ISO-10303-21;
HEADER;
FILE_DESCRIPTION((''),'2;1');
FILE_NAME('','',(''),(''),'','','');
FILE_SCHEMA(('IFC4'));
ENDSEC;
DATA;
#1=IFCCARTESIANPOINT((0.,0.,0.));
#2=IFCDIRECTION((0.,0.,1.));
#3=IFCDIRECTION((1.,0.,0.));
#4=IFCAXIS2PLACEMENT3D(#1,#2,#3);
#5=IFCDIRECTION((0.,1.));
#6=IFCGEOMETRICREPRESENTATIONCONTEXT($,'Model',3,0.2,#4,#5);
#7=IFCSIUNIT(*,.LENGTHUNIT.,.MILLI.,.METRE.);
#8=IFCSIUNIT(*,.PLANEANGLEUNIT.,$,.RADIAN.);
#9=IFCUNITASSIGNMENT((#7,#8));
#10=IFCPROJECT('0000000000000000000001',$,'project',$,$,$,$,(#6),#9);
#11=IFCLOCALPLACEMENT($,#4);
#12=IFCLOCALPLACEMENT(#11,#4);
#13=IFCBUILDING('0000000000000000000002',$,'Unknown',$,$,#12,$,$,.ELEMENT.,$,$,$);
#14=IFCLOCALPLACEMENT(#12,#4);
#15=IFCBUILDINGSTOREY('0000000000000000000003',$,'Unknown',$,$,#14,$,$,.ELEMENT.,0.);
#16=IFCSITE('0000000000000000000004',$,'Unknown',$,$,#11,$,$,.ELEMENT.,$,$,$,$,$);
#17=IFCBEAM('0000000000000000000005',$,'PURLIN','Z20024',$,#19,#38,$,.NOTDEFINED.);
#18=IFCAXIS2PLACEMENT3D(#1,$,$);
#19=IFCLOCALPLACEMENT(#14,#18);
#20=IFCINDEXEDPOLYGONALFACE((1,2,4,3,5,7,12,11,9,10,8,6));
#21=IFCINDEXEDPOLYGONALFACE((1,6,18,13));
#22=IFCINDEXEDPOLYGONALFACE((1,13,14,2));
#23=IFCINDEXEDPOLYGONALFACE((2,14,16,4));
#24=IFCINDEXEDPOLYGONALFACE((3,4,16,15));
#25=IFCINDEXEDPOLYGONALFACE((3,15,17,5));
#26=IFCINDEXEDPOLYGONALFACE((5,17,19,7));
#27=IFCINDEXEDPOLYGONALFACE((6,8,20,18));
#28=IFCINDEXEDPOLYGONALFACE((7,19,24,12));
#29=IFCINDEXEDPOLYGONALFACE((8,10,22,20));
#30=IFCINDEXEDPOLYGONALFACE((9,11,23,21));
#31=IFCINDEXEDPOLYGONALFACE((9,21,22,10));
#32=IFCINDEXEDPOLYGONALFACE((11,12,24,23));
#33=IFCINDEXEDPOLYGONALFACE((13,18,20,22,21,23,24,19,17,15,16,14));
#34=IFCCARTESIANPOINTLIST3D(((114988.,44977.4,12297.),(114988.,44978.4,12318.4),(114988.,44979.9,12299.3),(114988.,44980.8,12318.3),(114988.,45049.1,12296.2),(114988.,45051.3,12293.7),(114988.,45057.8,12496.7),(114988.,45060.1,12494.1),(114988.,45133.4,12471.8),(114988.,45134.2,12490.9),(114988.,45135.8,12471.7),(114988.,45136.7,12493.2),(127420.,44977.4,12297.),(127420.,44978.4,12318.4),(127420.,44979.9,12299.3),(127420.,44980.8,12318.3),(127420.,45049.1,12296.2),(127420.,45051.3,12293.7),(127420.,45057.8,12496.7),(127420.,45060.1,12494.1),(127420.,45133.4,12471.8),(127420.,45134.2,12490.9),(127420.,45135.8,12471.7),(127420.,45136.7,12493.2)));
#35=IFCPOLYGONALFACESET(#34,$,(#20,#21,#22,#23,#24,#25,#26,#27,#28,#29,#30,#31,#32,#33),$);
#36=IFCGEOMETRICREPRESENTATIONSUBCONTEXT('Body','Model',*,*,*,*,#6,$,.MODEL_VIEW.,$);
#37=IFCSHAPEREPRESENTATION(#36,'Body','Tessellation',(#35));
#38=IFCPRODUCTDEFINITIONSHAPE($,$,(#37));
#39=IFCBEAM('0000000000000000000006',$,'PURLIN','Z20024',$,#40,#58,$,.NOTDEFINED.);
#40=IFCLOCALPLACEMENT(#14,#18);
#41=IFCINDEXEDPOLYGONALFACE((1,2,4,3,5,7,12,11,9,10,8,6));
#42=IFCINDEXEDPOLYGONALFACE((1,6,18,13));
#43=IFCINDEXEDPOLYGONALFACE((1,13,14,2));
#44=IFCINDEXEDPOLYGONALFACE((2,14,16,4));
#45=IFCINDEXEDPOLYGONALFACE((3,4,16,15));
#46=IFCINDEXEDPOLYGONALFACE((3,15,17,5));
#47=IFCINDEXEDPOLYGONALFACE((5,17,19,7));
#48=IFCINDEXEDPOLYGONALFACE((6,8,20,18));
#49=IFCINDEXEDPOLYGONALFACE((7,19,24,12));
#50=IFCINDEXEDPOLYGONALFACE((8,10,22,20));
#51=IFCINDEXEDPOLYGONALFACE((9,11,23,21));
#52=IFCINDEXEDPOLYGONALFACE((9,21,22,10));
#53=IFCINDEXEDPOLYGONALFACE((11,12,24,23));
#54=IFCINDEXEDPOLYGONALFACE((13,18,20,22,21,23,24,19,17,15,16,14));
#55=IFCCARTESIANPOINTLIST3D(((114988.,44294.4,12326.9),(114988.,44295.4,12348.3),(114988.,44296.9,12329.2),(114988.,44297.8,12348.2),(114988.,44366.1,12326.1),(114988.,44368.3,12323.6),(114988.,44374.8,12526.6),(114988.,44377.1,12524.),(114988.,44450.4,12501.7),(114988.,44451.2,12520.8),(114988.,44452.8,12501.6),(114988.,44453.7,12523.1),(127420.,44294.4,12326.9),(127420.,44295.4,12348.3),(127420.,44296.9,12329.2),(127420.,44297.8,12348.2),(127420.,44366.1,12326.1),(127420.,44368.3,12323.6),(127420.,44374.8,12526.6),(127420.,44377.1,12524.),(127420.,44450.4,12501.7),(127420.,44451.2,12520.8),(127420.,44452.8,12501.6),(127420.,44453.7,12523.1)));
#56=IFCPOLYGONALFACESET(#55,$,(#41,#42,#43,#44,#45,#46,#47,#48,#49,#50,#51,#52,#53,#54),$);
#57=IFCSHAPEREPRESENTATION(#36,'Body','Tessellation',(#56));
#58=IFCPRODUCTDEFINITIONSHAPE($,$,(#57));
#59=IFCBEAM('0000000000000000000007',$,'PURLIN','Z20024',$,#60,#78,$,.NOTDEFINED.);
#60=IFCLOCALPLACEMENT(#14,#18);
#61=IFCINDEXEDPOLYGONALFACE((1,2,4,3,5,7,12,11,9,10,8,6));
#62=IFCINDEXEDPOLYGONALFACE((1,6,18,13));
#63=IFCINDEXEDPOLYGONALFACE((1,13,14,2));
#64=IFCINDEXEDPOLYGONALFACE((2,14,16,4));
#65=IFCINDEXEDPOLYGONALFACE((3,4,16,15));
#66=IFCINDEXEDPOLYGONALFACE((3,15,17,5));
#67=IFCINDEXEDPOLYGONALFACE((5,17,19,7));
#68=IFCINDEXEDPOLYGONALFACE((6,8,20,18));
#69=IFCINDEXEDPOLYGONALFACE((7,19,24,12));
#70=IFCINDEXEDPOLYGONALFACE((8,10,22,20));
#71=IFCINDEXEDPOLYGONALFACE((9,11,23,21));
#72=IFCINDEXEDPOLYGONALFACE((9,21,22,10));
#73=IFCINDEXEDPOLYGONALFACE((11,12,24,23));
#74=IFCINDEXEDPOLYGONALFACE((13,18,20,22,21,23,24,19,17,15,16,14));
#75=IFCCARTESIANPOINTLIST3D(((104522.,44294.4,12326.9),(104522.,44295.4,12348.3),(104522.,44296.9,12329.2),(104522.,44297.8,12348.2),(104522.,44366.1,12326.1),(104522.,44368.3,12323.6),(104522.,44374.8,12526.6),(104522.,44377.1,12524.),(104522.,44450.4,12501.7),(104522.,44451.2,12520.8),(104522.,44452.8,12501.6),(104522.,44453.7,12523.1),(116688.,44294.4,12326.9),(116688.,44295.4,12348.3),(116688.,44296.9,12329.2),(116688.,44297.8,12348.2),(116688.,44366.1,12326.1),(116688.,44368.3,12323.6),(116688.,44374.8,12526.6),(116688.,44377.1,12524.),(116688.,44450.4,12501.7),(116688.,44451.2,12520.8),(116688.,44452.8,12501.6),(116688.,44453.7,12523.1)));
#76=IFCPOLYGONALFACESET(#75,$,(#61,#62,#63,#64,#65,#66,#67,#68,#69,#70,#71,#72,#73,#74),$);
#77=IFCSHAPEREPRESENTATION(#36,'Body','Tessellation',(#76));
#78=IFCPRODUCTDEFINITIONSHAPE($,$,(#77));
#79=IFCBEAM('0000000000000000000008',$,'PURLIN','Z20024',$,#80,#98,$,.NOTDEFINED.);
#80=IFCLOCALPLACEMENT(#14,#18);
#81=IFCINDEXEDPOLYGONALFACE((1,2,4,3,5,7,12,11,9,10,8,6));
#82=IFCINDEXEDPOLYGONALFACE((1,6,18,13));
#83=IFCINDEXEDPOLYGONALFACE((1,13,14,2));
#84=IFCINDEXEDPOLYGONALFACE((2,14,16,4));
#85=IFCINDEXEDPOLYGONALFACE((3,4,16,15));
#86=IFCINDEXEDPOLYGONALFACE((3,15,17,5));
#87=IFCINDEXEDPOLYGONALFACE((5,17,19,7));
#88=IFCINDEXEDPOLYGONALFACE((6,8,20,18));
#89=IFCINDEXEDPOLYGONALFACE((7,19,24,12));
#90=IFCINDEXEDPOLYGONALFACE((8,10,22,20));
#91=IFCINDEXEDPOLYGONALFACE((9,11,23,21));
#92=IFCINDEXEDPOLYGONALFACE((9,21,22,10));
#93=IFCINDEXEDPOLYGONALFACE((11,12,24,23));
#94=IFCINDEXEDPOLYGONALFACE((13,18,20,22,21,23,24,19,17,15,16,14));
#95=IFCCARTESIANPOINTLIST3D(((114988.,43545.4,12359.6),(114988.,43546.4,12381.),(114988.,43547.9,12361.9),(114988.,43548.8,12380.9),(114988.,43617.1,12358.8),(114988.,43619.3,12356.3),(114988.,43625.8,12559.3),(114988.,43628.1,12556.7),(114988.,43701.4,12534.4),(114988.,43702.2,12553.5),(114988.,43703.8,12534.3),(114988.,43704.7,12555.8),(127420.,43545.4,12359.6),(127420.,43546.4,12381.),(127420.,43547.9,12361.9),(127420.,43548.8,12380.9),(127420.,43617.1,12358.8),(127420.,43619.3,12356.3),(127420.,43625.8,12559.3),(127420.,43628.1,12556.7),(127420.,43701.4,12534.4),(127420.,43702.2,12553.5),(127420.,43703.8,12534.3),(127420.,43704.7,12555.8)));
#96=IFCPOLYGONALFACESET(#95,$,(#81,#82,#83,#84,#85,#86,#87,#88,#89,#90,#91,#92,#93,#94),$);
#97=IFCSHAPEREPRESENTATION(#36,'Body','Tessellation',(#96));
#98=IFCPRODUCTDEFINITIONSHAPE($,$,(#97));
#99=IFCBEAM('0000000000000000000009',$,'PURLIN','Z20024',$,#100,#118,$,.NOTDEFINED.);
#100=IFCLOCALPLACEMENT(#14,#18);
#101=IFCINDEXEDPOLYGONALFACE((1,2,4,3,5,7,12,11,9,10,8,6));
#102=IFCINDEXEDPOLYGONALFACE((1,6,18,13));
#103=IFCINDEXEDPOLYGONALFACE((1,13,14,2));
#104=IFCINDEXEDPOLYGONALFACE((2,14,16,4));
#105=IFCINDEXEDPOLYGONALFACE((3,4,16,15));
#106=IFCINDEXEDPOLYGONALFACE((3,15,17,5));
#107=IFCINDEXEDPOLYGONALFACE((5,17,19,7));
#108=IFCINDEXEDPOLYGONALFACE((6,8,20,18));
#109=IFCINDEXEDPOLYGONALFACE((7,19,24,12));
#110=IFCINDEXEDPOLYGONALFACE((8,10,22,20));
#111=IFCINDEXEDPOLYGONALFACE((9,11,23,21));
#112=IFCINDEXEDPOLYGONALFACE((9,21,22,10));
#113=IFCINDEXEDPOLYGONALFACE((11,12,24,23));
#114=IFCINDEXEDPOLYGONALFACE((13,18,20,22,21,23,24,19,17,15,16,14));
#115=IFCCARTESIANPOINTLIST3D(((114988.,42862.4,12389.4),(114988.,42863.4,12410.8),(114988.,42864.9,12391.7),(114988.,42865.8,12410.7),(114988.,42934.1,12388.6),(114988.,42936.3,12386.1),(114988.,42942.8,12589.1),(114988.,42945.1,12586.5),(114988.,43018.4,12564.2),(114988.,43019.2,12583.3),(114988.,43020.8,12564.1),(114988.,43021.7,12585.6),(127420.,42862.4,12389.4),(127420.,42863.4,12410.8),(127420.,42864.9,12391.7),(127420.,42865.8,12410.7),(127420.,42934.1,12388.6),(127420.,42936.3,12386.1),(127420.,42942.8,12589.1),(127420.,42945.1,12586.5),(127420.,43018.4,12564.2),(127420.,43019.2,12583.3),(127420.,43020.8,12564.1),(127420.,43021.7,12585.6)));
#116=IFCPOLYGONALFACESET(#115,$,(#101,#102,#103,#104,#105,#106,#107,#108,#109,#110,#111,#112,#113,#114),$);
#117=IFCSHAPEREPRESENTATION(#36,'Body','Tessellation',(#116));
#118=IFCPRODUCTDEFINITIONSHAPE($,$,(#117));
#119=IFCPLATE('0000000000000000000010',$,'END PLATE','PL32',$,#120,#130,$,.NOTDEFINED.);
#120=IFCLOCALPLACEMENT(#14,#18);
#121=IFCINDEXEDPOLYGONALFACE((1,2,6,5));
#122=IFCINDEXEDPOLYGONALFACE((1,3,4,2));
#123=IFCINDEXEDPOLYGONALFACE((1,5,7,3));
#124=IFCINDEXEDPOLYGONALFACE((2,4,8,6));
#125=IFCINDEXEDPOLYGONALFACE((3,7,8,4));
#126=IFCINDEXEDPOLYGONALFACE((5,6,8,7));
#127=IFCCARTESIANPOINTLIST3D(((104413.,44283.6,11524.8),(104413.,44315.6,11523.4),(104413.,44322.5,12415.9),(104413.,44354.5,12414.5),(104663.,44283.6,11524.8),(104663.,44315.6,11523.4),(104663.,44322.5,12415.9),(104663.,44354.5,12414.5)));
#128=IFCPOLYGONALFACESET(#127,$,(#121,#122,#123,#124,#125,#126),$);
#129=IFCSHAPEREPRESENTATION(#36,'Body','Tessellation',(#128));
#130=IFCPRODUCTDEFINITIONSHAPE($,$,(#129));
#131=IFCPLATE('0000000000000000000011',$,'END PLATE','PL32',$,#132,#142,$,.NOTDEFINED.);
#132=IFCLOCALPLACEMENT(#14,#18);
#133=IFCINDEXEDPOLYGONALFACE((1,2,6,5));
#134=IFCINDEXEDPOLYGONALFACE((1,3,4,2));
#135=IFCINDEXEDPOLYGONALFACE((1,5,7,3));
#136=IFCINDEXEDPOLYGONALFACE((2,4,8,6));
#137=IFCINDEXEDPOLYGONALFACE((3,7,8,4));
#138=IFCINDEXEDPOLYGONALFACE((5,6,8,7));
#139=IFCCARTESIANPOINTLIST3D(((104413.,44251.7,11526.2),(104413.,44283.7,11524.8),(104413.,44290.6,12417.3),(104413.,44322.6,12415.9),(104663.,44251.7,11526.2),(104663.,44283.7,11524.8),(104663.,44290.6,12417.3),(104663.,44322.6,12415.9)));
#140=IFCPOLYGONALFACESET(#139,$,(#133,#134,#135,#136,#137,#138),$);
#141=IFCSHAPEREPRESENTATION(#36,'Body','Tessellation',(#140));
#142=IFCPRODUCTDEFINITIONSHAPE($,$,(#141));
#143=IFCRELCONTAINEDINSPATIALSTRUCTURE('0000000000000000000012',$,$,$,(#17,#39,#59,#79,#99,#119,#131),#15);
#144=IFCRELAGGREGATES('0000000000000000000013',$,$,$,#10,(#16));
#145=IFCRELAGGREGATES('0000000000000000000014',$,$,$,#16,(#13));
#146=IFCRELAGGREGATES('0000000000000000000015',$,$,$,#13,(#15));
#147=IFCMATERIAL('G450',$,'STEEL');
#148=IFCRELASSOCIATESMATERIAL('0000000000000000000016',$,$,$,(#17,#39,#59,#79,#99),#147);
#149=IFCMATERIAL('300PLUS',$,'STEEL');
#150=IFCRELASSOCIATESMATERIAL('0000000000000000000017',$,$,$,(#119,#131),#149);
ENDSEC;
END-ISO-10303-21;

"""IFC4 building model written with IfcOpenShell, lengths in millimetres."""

from ifc_helpers import new_model, si_unit, direction, frame, origin_with_axes, place, context, subcontext, project, spatial, line, indexed_curve, outline, extrude, material, element, save


model = new_model("IFC4")

# Units and contexts
model_context = context("Model", 3, precision=0.2, world=origin_with_axes(), true_north=direction((0.0, 1.0)))
body_context = subcontext(model_context, "Body", "Model", "MODEL_VIEW")
ifc_project = project(units=[si_unit("LENGTHUNIT", "METRE", prefix="MILLI"), si_unit("PLANEANGLEUNIT", "RADIAN")], contexts=[model_context])

# Site, building, storey
site_placement = place(None, origin_with_axes())
site = spatial("IfcSite", under=ifc_project, at=site_placement, Name="Unknown", CompositionType="ELEMENT")
building_placement = place(site_placement, origin_with_axes())
building = spatial("IfcBuilding", under=site, at=building_placement, Name="Unknown", CompositionType="ELEMENT")
storey_placement = place(building_placement, origin_with_axes())
storey = spatial("IfcBuildingStorey", under=building, at=storey_placement, Name="Unknown", CompositionType="ELEMENT", Elevation=0.0)

# Beams
ifc_material_1 = material(Name="G450", Category="STEEL")
for number, where, z_axis, x_axis, name in (
    (1, (114988.0, 45054.6, 12395.2), (0.0, -0.999048, 0.043619), (1.0, 0.0, 0.0), "PURLIN"),
    (2, (114988.0, 44371.6, 12425.1), (0.0, -0.999048, 0.043619), (1.0, 0.0, 0.0), "PURLIN"),
):
    element("IfcBeam", number, at=place(storey_placement, frame(where, z_axis=z_axis, x_axis=x_axis)), inside=storey, material=ifc_material_1, Name=name, Description="Z20024", PredefinedType="NOTDEFINED", context=body_context, shape_type="SolidModel", body=[
        extrude(outline(indexed_curve([(72.8, -101.5), (72.8, -80.0), (70.4, -80.0), (70.4, -99.1), (1.2, -99.1), (1.2, 101.5), (-77.8, 101.5), (-77.8, 80.0), (-75.4, 80.0), (-75.4, 99.1), (-1.2, 99.1), (-1.2, -101.5)], segments=[line(1, 2, 3, 4, 5, 6, 7, 8, 9, 10, 11, 12, 1)])), frame((0.0, 0.0, 0.0), z_axis=(-1.0, 0.0, 0.0), x_axis=(0.0, 0.0, 1.0)), (0.0, 0.0, -1.0), 12432.0),
    ])
beam_1_placement = place(storey_placement, frame((104522.0, 44371.6, 12425.1), z_axis=(0.0, -0.999048, 0.043619), x_axis=(1.0, 0.0, 0.0)))
element("IfcBeam", 3, at=beam_1_placement, inside=storey, material=ifc_material_1, Name="PURLIN", Description="Z20024", PredefinedType="NOTDEFINED", context=body_context, shape_type="SolidModel", body=[
    extrude(outline(indexed_curve([(72.8, -101.5), (72.8, -80.0), (70.4, -80.0), (70.4, -99.1), (1.2, -99.1), (1.2, 101.5), (-77.8, 101.5), (-77.8, 80.0), (-75.4, 80.0), (-75.4, 99.1), (-1.2, 99.1), (-1.2, -101.5)], segments=[line(1, 2, 3, 4, 5, 6, 7, 8, 9, 10, 11, 12, 1)])), frame((0.0, 0.0, 0.0), z_axis=(-1.0, 0.0, 0.0), x_axis=(0.0, 0.0, 1.0)), (0.0, 0.0, -1.0), 12166.0),
])
for number, where, z_axis, x_axis, name in (
    (4, (114988.0, 43622.6, 12457.8), (0.0, -0.999048, 0.043619), (1.0, 0.0, 0.0), "PURLIN"),
    (5, (114988.0, 42939.6, 12487.6), (0.0, -0.999048, 0.043619), (1.0, 0.0, 0.0), "PURLIN"),
):
    element("IfcBeam", number, at=place(storey_placement, frame(where, z_axis=z_axis, x_axis=x_axis)), inside=storey, material=ifc_material_1, Name=name, Description="Z20024", PredefinedType="NOTDEFINED", context=body_context, shape_type="SolidModel", body=[
        extrude(outline(indexed_curve([(72.8, -101.5), (72.8, -80.0), (70.4, -80.0), (70.4, -99.1), (1.2, -99.1), (1.2, 101.5), (-77.8, 101.5), (-77.8, 80.0), (-75.4, 80.0), (-75.4, 99.1), (-1.2, 99.1), (-1.2, -101.5)], segments=[line(1, 2, 3, 4, 5, 6, 7, 8, 9, 10, 11, 12, 1)])), frame((0.0, 0.0, 0.0), z_axis=(-1.0, 0.0, 0.0), x_axis=(0.0, 0.0, 1.0)), (0.0, 0.0, -1.0), 12432.0),
    ])

# Plates
ifc_material_2 = material(Name="300PLUS", Category="STEEL")
for number, where, z_axis, x_axis, name in (
    (6, (104663.0, 44338.5, 12415.2), (0.0, -0.999049, 0.043612), (-1.0, 0.0, 0.0), "END PLATE"),
    (7, (104663.0, 44306.6, 12416.6), (0.0, -0.999049, 0.043612), (-1.0, 0.0, 0.0), "END PLATE"),
):
    element("IfcPlate", number, at=place(storey_placement, frame(where, z_axis=z_axis, x_axis=x_axis)), inside=storey, material=ifc_material_2, Name=name, Description="PL32", PredefinedType="NOTDEFINED", context=body_context, shape_type="SolidModel", body=[
        extrude(outline(indexed_curve([(0.0, 0.0), (250.0, 0.0), (250.0, 891.9), (0.0, 891.9)], segments=[line(1, 2, 3, 4, 1)])), frame((0.0, 0.0, 16.0), z_axis=(0.0, 0.0, 1.0), x_axis=(1.0, 0.0, 0.0)), (0.0, 0.0, -1.0), 32.0),
    ])

save(model, "model.ifc")
